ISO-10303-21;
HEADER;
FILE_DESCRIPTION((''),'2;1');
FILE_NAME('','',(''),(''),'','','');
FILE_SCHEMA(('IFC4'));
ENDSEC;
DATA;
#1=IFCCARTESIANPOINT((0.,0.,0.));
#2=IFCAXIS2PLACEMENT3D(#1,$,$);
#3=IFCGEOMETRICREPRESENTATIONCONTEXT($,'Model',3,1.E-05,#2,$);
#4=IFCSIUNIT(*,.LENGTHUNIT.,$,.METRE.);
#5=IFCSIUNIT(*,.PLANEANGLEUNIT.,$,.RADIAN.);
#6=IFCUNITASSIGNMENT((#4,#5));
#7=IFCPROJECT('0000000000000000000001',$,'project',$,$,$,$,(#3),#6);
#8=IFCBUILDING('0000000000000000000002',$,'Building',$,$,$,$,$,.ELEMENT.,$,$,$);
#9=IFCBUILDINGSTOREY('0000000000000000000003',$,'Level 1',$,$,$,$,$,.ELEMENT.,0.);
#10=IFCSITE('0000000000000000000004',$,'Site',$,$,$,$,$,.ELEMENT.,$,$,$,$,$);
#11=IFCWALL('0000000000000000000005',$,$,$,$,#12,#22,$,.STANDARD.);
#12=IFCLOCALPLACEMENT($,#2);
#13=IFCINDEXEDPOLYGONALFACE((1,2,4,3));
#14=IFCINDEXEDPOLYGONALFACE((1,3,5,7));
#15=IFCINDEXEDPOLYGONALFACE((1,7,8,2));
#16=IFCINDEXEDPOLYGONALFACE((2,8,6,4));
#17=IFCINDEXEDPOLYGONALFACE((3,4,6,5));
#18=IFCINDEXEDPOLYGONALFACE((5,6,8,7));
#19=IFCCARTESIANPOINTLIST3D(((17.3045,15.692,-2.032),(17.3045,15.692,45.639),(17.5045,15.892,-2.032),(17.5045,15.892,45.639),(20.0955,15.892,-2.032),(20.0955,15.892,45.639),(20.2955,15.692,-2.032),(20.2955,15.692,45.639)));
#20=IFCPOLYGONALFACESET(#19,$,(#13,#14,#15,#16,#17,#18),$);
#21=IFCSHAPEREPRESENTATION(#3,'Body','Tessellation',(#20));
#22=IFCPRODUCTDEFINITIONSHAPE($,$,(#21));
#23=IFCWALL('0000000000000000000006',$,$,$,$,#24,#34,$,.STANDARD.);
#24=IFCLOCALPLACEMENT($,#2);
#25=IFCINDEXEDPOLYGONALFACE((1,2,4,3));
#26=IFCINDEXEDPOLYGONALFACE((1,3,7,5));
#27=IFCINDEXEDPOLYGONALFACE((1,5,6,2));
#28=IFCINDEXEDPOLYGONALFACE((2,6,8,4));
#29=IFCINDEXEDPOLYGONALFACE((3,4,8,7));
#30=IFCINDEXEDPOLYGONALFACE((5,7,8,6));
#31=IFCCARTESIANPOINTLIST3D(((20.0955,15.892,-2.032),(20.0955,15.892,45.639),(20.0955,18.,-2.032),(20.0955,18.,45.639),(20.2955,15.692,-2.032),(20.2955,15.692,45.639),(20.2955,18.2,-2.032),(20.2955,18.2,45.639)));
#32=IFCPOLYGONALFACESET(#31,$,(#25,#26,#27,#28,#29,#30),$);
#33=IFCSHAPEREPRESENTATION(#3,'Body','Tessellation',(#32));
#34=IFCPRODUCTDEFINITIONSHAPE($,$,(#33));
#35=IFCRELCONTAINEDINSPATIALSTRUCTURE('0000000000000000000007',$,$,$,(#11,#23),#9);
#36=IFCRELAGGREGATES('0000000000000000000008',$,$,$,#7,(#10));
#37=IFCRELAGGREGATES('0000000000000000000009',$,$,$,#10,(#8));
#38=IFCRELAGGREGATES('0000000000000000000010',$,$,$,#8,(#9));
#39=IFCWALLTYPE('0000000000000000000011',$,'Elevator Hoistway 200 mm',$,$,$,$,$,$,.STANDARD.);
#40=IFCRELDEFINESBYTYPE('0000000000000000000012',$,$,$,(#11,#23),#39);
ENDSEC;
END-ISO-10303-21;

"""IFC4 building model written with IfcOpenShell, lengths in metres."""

from ifc_helpers import new_model, si_unit, frame, origin, place, context, project, spatial, polyline, outline, extrude, type_object, element, save


model = new_model("IFC4")

# Units and contexts
model_context = context("Model", 3, precision=1e-05, world=origin())
ifc_project = project(units=[si_unit("LENGTHUNIT", "METRE"), si_unit("PLANEANGLEUNIT", "RADIAN")], contexts=[model_context])

# Site, building, storey
site = spatial("IfcSite", under=ifc_project, Name="Site", CompositionType="ELEMENT")
building = spatial("IfcBuilding", under=site, Name="Building", CompositionType="ELEMENT")
storey = spatial("IfcBuildingStorey", under=building, Name="Level 1", CompositionType="ELEMENT", Elevation=0.0)

# Shared definitions
wall_type = type_object("IfcWallType", Name="Elevator Hoistway 200 mm", PredefinedType="STANDARD")

# Walls
wall_1_placement = place(None, frame((17.4045, 15.792, -2.032), z_axis=(0.0, 0.0, 1.0), x_axis=(1.0, 0.0, 0.0)))
element("IfcWall", 1, at=wall_1_placement, inside=storey, type_object=wall_type, PredefinedType="STANDARD", context=model_context, shape_type="SweptSolid", body=[
    extrude(outline(polyline([(-0.1, -0.1), (2.891, -0.1), (2.691, 0.1), (0.1, 0.1), (-0.1, -0.1)])), origin(), (0.0, 0.0, 1.0), 47.671),
])
wall_2_placement = place(None, frame((20.1955, 15.792, -2.032), z_axis=(0.0, 0.0, 1.0), x_axis=(0.0, 1.0, 0.0)))
element("IfcWall", 2, at=wall_2_placement, inside=storey, type_object=wall_type, PredefinedType="STANDARD", context=model_context, shape_type="SweptSolid", body=[
    extrude(outline(polyline([(-0.1, -0.1), (2.408, -0.1), (2.208, 0.1), (0.1, 0.1), (-0.1, -0.1)])), origin(), (0.0, 0.0, 1.0), 47.671),
])

save(model, "model.ifc")
